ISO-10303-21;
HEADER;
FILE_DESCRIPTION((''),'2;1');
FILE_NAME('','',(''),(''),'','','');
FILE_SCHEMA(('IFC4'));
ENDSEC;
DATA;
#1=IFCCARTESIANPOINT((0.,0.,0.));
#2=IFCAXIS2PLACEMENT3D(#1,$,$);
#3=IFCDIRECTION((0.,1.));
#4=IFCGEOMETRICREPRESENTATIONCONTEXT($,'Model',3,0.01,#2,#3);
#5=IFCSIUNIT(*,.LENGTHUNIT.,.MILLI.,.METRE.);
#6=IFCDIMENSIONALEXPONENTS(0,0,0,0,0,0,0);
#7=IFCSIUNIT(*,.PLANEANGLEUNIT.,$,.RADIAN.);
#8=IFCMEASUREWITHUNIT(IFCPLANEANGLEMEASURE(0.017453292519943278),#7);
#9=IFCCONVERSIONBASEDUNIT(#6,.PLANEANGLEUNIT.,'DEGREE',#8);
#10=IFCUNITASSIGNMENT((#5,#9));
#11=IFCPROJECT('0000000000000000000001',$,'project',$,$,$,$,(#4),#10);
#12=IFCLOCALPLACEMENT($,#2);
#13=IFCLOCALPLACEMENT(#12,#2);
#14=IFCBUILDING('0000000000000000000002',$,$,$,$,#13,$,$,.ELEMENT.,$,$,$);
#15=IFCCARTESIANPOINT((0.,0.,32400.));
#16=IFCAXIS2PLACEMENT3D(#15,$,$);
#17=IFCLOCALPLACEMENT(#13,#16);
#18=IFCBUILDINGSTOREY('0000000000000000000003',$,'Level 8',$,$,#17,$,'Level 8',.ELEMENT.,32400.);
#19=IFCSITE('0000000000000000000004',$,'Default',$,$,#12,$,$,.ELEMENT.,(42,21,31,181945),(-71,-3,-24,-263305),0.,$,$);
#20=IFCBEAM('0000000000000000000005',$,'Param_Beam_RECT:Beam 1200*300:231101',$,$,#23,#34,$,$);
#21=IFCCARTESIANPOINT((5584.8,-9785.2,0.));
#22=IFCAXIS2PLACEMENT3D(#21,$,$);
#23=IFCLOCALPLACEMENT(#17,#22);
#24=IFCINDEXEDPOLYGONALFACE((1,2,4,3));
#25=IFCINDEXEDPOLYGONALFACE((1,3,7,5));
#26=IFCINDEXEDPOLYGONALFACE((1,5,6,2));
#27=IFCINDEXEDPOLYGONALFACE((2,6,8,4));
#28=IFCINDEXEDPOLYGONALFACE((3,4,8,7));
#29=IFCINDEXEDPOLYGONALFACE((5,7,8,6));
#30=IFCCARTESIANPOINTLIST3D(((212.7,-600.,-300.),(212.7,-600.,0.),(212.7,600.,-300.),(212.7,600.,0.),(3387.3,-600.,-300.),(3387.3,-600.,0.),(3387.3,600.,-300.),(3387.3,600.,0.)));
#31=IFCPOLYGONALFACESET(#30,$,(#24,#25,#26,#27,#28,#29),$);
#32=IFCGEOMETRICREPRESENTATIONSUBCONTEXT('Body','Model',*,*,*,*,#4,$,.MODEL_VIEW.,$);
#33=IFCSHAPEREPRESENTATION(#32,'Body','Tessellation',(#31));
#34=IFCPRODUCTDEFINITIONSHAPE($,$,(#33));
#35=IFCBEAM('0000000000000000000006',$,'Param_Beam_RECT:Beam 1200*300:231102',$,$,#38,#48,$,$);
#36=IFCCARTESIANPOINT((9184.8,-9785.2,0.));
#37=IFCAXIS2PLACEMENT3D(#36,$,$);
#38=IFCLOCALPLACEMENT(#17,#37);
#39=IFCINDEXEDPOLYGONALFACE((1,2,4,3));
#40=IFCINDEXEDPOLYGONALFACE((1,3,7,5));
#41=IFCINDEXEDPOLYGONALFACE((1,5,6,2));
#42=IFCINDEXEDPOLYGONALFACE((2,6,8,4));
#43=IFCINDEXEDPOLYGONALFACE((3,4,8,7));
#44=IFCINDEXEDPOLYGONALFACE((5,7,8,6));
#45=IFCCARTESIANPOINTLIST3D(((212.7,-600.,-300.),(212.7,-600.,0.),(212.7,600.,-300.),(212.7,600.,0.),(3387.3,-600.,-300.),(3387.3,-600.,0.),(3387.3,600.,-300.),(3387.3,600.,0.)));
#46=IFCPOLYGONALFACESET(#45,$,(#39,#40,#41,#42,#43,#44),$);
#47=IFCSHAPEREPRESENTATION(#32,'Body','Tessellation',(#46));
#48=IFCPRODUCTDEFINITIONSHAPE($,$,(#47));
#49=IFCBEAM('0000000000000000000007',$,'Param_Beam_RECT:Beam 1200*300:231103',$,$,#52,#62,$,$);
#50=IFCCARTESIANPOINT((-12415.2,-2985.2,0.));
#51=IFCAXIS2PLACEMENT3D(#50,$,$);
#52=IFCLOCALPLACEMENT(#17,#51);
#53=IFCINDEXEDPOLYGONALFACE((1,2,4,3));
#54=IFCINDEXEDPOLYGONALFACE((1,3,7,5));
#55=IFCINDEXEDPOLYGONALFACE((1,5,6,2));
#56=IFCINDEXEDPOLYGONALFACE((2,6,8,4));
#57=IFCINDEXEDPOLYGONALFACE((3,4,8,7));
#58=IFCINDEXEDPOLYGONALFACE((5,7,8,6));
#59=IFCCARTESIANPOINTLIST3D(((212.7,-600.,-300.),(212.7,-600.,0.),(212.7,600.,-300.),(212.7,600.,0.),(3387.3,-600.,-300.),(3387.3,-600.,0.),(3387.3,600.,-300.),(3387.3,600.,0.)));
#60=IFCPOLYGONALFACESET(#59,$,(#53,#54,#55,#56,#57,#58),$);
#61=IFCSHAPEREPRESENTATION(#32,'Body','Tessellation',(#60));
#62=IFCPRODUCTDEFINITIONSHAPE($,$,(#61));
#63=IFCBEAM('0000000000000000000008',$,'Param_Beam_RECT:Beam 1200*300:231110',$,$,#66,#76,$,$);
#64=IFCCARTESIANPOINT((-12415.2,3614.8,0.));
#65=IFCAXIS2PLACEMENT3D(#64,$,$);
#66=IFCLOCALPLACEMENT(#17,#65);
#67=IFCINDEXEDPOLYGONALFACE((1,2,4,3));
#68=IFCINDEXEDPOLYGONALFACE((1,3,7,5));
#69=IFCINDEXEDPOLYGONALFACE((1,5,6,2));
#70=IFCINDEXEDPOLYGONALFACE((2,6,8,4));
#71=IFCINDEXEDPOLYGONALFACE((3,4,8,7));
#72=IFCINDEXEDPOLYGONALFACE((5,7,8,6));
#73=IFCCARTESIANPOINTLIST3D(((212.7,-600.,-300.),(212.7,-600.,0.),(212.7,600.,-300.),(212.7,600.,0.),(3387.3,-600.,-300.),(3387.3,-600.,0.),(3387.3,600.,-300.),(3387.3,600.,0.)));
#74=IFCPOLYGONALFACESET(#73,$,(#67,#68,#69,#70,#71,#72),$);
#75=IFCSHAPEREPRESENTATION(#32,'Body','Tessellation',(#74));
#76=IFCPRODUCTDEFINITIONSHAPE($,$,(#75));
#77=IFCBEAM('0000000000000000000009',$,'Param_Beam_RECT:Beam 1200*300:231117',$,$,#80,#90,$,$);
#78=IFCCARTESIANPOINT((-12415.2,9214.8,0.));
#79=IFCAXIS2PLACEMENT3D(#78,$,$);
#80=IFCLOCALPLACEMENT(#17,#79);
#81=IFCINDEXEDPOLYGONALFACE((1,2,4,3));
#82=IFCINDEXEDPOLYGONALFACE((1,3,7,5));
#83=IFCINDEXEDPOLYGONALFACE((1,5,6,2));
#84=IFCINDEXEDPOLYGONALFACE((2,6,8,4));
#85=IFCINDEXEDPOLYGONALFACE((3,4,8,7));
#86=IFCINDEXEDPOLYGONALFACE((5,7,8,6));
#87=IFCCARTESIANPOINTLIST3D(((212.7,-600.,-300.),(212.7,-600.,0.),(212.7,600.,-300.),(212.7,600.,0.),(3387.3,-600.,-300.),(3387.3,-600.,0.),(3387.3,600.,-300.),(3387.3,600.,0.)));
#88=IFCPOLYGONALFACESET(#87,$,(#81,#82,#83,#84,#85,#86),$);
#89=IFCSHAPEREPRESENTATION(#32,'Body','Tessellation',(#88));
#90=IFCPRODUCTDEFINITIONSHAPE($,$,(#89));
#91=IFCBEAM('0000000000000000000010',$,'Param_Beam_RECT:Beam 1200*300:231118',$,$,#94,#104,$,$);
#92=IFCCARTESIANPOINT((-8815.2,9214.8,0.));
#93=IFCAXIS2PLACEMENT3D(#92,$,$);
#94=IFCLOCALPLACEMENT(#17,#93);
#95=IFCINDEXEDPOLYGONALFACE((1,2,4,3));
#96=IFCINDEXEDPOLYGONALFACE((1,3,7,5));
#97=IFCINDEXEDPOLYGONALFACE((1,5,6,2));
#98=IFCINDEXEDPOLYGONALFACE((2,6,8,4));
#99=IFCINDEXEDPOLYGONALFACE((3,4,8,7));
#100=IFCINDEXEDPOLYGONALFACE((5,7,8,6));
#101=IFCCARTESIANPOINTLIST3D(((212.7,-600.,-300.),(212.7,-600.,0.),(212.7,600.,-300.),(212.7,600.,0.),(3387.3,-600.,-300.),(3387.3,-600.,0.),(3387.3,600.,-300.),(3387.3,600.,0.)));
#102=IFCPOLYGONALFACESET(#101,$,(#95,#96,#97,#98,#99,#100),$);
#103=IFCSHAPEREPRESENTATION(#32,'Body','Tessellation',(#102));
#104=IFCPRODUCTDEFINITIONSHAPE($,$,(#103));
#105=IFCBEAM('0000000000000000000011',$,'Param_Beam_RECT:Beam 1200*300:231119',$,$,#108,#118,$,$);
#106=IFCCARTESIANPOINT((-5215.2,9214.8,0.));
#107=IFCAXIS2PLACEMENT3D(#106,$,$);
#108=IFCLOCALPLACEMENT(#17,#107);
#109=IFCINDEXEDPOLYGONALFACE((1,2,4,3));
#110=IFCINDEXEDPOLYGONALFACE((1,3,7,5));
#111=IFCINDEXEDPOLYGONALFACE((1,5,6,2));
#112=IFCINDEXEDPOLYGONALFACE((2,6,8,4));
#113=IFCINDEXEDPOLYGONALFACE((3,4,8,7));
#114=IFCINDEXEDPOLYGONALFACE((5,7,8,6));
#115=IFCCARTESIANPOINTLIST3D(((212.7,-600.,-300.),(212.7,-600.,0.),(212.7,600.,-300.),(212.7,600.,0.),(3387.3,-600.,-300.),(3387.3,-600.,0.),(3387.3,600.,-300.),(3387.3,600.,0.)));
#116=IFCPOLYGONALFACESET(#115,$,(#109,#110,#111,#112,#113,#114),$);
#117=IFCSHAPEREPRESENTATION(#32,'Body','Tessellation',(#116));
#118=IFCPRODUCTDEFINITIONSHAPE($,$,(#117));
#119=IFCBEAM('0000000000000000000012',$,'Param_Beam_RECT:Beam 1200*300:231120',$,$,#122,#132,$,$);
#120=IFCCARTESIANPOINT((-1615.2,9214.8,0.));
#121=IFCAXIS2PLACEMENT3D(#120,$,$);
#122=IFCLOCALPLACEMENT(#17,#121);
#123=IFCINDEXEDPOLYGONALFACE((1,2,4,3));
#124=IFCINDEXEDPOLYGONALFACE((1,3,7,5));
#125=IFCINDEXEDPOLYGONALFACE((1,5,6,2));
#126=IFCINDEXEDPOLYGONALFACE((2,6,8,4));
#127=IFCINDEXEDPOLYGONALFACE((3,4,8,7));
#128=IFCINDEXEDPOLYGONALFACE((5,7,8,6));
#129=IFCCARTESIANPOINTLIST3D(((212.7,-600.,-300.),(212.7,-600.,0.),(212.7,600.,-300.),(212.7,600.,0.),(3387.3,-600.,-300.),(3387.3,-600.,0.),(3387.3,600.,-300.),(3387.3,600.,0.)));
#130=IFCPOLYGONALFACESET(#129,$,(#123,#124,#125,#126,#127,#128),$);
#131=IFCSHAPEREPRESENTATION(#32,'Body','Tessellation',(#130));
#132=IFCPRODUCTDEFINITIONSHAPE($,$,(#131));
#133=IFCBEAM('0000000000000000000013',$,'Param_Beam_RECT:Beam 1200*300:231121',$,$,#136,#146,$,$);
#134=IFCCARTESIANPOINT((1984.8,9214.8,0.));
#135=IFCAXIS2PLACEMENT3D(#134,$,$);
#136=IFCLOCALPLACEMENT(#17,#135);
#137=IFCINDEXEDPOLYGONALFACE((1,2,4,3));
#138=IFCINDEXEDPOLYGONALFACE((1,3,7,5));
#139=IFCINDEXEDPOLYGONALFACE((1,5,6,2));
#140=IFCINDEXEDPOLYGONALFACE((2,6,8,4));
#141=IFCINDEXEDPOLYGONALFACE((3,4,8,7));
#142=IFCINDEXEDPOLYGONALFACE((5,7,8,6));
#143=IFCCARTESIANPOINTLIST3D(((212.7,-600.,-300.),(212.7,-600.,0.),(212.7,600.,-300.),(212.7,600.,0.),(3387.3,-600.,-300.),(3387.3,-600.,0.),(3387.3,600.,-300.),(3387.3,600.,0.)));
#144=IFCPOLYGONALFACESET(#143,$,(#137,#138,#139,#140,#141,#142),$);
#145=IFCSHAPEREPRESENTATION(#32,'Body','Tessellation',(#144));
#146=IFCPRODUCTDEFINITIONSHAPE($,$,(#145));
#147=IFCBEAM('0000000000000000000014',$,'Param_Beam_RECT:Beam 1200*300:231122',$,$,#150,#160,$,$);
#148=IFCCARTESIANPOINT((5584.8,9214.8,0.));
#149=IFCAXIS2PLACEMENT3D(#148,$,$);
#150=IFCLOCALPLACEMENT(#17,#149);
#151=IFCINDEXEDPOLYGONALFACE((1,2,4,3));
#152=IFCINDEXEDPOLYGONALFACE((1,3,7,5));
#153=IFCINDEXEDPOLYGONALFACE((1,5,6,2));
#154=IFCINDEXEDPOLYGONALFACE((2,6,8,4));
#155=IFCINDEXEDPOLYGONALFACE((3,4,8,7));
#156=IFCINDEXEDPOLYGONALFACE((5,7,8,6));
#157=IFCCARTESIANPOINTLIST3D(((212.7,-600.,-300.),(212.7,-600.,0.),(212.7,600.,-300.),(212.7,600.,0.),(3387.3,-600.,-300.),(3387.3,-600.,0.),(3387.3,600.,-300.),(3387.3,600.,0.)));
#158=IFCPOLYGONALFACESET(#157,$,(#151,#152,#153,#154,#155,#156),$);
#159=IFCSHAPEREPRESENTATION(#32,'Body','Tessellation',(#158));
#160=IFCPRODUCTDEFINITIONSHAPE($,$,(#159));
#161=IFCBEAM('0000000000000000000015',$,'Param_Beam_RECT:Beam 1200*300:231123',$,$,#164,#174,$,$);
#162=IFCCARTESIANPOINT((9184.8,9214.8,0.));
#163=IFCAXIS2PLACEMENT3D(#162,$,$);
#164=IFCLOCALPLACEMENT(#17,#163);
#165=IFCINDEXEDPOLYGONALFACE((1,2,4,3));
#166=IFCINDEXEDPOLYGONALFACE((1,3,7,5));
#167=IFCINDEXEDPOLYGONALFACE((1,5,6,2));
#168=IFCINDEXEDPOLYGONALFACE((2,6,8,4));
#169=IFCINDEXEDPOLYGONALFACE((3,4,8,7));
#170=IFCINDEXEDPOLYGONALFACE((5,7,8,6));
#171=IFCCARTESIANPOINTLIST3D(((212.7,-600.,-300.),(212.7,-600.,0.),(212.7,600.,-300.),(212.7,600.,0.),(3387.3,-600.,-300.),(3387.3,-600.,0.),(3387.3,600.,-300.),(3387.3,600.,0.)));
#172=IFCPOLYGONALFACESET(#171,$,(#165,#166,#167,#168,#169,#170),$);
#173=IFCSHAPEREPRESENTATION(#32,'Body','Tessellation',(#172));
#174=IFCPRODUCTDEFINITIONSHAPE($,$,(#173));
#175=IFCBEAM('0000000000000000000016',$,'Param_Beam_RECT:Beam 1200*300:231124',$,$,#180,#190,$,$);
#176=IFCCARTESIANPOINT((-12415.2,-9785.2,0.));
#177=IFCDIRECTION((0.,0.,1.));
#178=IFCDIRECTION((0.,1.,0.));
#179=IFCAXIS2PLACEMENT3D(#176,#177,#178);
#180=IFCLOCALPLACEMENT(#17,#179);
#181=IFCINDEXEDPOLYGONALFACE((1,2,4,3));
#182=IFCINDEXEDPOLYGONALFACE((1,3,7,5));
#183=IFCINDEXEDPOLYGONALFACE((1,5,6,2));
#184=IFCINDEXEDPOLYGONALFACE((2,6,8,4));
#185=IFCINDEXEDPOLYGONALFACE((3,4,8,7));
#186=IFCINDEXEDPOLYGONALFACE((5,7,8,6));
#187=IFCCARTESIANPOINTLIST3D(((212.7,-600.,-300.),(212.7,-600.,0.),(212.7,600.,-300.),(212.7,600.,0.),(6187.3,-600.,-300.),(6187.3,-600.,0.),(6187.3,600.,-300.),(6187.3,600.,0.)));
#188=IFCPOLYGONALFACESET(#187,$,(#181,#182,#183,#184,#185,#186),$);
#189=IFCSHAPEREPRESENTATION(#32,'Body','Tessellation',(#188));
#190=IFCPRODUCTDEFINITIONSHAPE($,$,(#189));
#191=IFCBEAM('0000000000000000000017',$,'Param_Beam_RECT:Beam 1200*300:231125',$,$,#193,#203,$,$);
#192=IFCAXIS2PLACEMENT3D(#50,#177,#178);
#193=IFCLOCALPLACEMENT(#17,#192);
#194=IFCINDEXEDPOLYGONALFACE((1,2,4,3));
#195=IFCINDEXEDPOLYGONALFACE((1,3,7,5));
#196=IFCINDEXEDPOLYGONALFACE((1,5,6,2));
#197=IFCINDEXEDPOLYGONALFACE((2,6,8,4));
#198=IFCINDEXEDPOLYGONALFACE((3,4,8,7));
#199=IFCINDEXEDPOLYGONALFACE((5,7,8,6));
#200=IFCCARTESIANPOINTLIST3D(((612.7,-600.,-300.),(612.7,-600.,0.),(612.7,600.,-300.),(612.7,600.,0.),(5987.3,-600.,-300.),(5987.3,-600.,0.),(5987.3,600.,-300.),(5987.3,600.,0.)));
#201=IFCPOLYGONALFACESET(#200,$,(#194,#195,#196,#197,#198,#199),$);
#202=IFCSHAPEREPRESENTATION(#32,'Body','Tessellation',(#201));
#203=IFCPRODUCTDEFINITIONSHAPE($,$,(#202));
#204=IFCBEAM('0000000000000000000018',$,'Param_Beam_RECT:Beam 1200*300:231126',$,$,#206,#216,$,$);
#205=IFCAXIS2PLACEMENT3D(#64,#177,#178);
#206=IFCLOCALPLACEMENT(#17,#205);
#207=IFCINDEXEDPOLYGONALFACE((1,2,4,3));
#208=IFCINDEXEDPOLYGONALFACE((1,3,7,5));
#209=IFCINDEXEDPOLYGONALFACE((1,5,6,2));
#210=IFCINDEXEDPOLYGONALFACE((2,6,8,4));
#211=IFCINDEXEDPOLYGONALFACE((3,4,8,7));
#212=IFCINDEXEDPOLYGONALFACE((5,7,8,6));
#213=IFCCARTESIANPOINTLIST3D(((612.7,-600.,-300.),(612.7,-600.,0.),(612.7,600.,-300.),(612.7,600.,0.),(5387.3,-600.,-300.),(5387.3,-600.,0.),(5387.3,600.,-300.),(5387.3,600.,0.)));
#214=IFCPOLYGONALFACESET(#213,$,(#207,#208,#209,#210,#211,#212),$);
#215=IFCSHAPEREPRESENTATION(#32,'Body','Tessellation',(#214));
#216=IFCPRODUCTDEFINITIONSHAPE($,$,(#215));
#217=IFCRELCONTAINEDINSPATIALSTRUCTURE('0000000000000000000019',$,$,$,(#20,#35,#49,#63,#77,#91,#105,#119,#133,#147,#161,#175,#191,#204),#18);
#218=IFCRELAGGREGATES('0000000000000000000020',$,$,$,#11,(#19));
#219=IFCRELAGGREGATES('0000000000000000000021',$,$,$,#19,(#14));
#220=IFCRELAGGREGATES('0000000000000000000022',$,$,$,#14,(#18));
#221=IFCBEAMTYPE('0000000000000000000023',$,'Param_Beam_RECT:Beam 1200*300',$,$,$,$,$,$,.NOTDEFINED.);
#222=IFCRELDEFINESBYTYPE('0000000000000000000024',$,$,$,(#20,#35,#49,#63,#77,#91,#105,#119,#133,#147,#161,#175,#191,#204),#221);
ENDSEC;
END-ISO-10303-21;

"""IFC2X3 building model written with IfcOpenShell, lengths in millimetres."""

from ifc_helpers import new_model, entity, si_unit, converted_unit, direction, frame, frame_2d, origin, origin_2d_with_axis, place, context, subcontext, project, spatial, rectangle, extrude, type_object, element, save


model = new_model("IFC2X3")

# Units and contexts
model_context = context("Model", 3, precision=0.01, world=origin(), true_north=direction((0.0, 1.0)))
body_context = subcontext(model_context, "Body", "Model", "MODEL_VIEW")
ifc_project = project(units=[si_unit("LENGTHUNIT", "METRE", prefix="MILLI"), converted_unit("PLANEANGLEUNIT", "DEGREE", entity("IfcPlaneAngleMeasure", 0.017453292519943278), si_unit("PLANEANGLEUNIT", "RADIAN"), dimensions=[0, 0, 0, 0, 0, 0, 0])], contexts=[model_context])

# Site, building, storey
site_placement = place(None, origin())
site = spatial("IfcSite", under=ifc_project, at=site_placement, Name="Default", CompositionType="ELEMENT", RefLatitude=(42, 21, 31, 181945), RefLongitude=(-71, -3, -24, -263305), RefElevation=0.0)
building_placement = place(site_placement, origin())
building = spatial("IfcBuilding", under=site, at=building_placement, CompositionType="ELEMENT")
storey_placement = place(building_placement, frame((0.0, 0.0, 32400.0)))
storey = spatial("IfcBuildingStorey", under=building, at=storey_placement, Name="Level 8", LongName="Level 8", CompositionType="ELEMENT", Elevation=32400.0)

# Beams
beam_type_1 = type_object("IfcBeamType", Name="Param_Beam_RECT:Beam 1200*300", PredefinedType="NOTDEFINED")
for number, where, name in (
    (1, (5584.8, -9785.2, 0.0), "Param_Beam_RECT:Beam 1200*300:231101"),
    (2, (9184.8, -9785.2, 0.0), "Param_Beam_RECT:Beam 1200*300:231102"),
):
    element("IfcBeam", number, at=place(storey_placement, frame(where)), inside=storey, type_object=beam_type_1, Name=name, context=body_context, shape_type="SweptSolid", body=[
        extrude(rectangle(XDim=300.0, YDim=1200.0, at=frame_2d((0.0, 0.0), x_axis=(1.0, 0.0))), frame((212.7, 0.0, -150.0), z_axis=(1.0, 0.0, 0.0), x_axis=(0.0, 0.0, -1.0)), (0.0, 0.0, 1.0), 3174.6),
    ])
beam_1_placement = place(storey_placement, frame((-12415.2, -2985.2, 0.0)))
element("IfcBeam", 3, at=beam_1_placement, inside=storey, type_object=beam_type_1, Name="Param_Beam_RECT:Beam 1200*300:231103", context=body_context, shape_type="SweptSolid", body=[
    extrude(rectangle(XDim=300.0, YDim=1200.0, at=frame_2d((0.0, 0.0), x_axis=(1.0, 0.0))), frame((212.7, 0.0, -150.0), z_axis=(1.0, 0.0, 0.0), x_axis=(0.0, 0.0, -1.0)), (0.0, 0.0, 1.0), 3174.6),
])
beam_2_placement = place(storey_placement, frame((-12415.2, 3614.8, 0.0)))
element("IfcBeam", 4, at=beam_2_placement, inside=storey, type_object=beam_type_1, Name="Param_Beam_RECT:Beam 1200*300:231110", context=body_context, shape_type="SweptSolid", body=[
    extrude(rectangle(XDim=300.0, YDim=1200.0, at=origin_2d_with_axis()), frame((212.7, 0.0, -150.0), z_axis=(1.0, 0.0, 0.0), x_axis=(0.0, 0.0, -1.0)), (0.0, 0.0, 1.0), 3174.6),
])
beam_3_placement = place(storey_placement, frame((-12415.2, 9214.8, 0.0)))
element("IfcBeam", 5, at=beam_3_placement, inside=storey, type_object=beam_type_1, Name="Param_Beam_RECT:Beam 1200*300:231117", context=body_context, shape_type="SweptSolid", body=[
    extrude(rectangle(XDim=300.0, YDim=1200.0, at=frame_2d((0.0, 0.0), x_axis=(1.0, 0.0))), frame((212.7, 0.0, -150.0), z_axis=(1.0, 0.0, 0.0), x_axis=(0.0, 0.0, -1.0)), (0.0, 0.0, 1.0), 3174.6),
])
for number, where, name in (
    (6, (-8815.2, 9214.8, 0.0), "Param_Beam_RECT:Beam 1200*300:231118"),
    (7, (-5215.2, 9214.8, 0.0), "Param_Beam_RECT:Beam 1200*300:231119"),
):
    element("IfcBeam", number, at=place(storey_placement, frame(where)), inside=storey, type_object=beam_type_1, Name=name, context=body_context, shape_type="SweptSolid", body=[
        extrude(rectangle(XDim=300.0, YDim=1200.0, at=frame_2d((0.0, 0.0), x_axis=(1.0, 0.0))), frame((212.7, 0.0, -150.0), z_axis=(1.0, 0.0, 0.0), x_axis=(0.0, 0.0, -1.0)), (0.0, 0.0, 1.0), 3174.6),
    ])
beam_4_placement = place(storey_placement, frame((-1615.2, 9214.8, 0.0)))
element("IfcBeam", 8, at=beam_4_placement, inside=storey, type_object=beam_type_1, Name="Param_Beam_RECT:Beam 1200*300:231120", context=body_context, shape_type="SweptSolid", body=[
    extrude(rectangle(XDim=300.0, YDim=1200.0, at=frame_2d((0.0, 0.0), x_axis=(1.0, 0.0))), frame((212.7, 0.0, -150.0), z_axis=(1.0, 0.0, 0.0), x_axis=(0.0, 0.0, -1.0)), (0.0, 0.0, 1.0), 3174.6),
])
beam_5_placement = place(storey_placement, frame((1984.8, 9214.8, 0.0)))
element("IfcBeam", 9, at=beam_5_placement, inside=storey, type_object=beam_type_1, Name="Param_Beam_RECT:Beam 1200*300:231121", context=body_context, shape_type="SweptSolid", body=[
    extrude(rectangle(XDim=300.0, YDim=1200.0, at=origin_2d_with_axis()), frame((212.7, 0.0, -150.0), z_axis=(1.0, 0.0, 0.0), x_axis=(0.0, 0.0, -1.0)), (0.0, 0.0, 1.0), 3174.6),
])
for number, where, name in (
    (10, (5584.8, 9214.8, 0.0), "Param_Beam_RECT:Beam 1200*300:231122"),
    (11, (9184.8, 9214.8, 0.0), "Param_Beam_RECT:Beam 1200*300:231123"),
):
    element("IfcBeam", number, at=place(storey_placement, frame(where)), inside=storey, type_object=beam_type_1, Name=name, context=body_context, shape_type="SweptSolid", body=[
        extrude(rectangle(XDim=300.0, YDim=1200.0, at=frame_2d((0.0, 0.0), x_axis=(1.0, 0.0))), frame((212.7, 0.0, -150.0), z_axis=(1.0, 0.0, 0.0), x_axis=(0.0, 0.0, -1.0)), (0.0, 0.0, 1.0), 3174.6),
    ])
beam_6_placement = place(storey_placement, frame((-12415.2, -9785.2, 0.0), z_axis=(0.0, 0.0, 1.0), x_axis=(0.0, 1.0, 0.0)))
element("IfcBeam", 12, at=beam_6_placement, inside=storey, type_object=beam_type_1, Name="Param_Beam_RECT:Beam 1200*300:231124", context=body_context, shape_type="SweptSolid", body=[
    extrude(rectangle(XDim=300.0, YDim=1200.0, at=origin_2d_with_axis()), frame((212.7, 0.0, -150.0), z_axis=(1.0, 0.0, 0.0), x_axis=(0.0, 0.0, -1.0)), (0.0, 0.0, 1.0), 5974.6),
])
beam_7_placement = place(storey_placement, frame((-12415.2, -2985.2, 0.0), z_axis=(0.0, 0.0, 1.0), x_axis=(0.0, 1.0, 0.0)))
element("IfcBeam", 13, at=beam_7_placement, inside=storey, type_object=beam_type_1, Name="Param_Beam_RECT:Beam 1200*300:231125", context=body_context, shape_type="SweptSolid", body=[
    extrude(rectangle(XDim=300.0, YDim=1200.0, at=frame_2d((0.0, 0.0), x_axis=(1.0, 0.0))), frame((612.7, 0.0, -150.0), z_axis=(1.0, 0.0, 0.0), x_axis=(0.0, 0.0, -1.0)), (0.0, 0.0, 1.0), 5374.6),
])
beam_8_placement = place(storey_placement, frame((-12415.2, 3614.8, 0.0), z_axis=(0.0, 0.0, 1.0), x_axis=(0.0, 1.0, 0.0)))
element("IfcBeam", 14, at=beam_8_placement, inside=storey, type_object=beam_type_1, Name="Param_Beam_RECT:Beam 1200*300:231126", context=body_context, shape_type="SweptSolid", body=[
    extrude(rectangle(XDim=300.0, YDim=1200.0, at=origin_2d_with_axis()), frame((612.7, 0.0, -150.0), z_axis=(1.0, 0.0, 0.0), x_axis=(0.0, 0.0, -1.0)), (0.0, 0.0, 1.0), 4774.6),
])

save(model, "model.ifc")
